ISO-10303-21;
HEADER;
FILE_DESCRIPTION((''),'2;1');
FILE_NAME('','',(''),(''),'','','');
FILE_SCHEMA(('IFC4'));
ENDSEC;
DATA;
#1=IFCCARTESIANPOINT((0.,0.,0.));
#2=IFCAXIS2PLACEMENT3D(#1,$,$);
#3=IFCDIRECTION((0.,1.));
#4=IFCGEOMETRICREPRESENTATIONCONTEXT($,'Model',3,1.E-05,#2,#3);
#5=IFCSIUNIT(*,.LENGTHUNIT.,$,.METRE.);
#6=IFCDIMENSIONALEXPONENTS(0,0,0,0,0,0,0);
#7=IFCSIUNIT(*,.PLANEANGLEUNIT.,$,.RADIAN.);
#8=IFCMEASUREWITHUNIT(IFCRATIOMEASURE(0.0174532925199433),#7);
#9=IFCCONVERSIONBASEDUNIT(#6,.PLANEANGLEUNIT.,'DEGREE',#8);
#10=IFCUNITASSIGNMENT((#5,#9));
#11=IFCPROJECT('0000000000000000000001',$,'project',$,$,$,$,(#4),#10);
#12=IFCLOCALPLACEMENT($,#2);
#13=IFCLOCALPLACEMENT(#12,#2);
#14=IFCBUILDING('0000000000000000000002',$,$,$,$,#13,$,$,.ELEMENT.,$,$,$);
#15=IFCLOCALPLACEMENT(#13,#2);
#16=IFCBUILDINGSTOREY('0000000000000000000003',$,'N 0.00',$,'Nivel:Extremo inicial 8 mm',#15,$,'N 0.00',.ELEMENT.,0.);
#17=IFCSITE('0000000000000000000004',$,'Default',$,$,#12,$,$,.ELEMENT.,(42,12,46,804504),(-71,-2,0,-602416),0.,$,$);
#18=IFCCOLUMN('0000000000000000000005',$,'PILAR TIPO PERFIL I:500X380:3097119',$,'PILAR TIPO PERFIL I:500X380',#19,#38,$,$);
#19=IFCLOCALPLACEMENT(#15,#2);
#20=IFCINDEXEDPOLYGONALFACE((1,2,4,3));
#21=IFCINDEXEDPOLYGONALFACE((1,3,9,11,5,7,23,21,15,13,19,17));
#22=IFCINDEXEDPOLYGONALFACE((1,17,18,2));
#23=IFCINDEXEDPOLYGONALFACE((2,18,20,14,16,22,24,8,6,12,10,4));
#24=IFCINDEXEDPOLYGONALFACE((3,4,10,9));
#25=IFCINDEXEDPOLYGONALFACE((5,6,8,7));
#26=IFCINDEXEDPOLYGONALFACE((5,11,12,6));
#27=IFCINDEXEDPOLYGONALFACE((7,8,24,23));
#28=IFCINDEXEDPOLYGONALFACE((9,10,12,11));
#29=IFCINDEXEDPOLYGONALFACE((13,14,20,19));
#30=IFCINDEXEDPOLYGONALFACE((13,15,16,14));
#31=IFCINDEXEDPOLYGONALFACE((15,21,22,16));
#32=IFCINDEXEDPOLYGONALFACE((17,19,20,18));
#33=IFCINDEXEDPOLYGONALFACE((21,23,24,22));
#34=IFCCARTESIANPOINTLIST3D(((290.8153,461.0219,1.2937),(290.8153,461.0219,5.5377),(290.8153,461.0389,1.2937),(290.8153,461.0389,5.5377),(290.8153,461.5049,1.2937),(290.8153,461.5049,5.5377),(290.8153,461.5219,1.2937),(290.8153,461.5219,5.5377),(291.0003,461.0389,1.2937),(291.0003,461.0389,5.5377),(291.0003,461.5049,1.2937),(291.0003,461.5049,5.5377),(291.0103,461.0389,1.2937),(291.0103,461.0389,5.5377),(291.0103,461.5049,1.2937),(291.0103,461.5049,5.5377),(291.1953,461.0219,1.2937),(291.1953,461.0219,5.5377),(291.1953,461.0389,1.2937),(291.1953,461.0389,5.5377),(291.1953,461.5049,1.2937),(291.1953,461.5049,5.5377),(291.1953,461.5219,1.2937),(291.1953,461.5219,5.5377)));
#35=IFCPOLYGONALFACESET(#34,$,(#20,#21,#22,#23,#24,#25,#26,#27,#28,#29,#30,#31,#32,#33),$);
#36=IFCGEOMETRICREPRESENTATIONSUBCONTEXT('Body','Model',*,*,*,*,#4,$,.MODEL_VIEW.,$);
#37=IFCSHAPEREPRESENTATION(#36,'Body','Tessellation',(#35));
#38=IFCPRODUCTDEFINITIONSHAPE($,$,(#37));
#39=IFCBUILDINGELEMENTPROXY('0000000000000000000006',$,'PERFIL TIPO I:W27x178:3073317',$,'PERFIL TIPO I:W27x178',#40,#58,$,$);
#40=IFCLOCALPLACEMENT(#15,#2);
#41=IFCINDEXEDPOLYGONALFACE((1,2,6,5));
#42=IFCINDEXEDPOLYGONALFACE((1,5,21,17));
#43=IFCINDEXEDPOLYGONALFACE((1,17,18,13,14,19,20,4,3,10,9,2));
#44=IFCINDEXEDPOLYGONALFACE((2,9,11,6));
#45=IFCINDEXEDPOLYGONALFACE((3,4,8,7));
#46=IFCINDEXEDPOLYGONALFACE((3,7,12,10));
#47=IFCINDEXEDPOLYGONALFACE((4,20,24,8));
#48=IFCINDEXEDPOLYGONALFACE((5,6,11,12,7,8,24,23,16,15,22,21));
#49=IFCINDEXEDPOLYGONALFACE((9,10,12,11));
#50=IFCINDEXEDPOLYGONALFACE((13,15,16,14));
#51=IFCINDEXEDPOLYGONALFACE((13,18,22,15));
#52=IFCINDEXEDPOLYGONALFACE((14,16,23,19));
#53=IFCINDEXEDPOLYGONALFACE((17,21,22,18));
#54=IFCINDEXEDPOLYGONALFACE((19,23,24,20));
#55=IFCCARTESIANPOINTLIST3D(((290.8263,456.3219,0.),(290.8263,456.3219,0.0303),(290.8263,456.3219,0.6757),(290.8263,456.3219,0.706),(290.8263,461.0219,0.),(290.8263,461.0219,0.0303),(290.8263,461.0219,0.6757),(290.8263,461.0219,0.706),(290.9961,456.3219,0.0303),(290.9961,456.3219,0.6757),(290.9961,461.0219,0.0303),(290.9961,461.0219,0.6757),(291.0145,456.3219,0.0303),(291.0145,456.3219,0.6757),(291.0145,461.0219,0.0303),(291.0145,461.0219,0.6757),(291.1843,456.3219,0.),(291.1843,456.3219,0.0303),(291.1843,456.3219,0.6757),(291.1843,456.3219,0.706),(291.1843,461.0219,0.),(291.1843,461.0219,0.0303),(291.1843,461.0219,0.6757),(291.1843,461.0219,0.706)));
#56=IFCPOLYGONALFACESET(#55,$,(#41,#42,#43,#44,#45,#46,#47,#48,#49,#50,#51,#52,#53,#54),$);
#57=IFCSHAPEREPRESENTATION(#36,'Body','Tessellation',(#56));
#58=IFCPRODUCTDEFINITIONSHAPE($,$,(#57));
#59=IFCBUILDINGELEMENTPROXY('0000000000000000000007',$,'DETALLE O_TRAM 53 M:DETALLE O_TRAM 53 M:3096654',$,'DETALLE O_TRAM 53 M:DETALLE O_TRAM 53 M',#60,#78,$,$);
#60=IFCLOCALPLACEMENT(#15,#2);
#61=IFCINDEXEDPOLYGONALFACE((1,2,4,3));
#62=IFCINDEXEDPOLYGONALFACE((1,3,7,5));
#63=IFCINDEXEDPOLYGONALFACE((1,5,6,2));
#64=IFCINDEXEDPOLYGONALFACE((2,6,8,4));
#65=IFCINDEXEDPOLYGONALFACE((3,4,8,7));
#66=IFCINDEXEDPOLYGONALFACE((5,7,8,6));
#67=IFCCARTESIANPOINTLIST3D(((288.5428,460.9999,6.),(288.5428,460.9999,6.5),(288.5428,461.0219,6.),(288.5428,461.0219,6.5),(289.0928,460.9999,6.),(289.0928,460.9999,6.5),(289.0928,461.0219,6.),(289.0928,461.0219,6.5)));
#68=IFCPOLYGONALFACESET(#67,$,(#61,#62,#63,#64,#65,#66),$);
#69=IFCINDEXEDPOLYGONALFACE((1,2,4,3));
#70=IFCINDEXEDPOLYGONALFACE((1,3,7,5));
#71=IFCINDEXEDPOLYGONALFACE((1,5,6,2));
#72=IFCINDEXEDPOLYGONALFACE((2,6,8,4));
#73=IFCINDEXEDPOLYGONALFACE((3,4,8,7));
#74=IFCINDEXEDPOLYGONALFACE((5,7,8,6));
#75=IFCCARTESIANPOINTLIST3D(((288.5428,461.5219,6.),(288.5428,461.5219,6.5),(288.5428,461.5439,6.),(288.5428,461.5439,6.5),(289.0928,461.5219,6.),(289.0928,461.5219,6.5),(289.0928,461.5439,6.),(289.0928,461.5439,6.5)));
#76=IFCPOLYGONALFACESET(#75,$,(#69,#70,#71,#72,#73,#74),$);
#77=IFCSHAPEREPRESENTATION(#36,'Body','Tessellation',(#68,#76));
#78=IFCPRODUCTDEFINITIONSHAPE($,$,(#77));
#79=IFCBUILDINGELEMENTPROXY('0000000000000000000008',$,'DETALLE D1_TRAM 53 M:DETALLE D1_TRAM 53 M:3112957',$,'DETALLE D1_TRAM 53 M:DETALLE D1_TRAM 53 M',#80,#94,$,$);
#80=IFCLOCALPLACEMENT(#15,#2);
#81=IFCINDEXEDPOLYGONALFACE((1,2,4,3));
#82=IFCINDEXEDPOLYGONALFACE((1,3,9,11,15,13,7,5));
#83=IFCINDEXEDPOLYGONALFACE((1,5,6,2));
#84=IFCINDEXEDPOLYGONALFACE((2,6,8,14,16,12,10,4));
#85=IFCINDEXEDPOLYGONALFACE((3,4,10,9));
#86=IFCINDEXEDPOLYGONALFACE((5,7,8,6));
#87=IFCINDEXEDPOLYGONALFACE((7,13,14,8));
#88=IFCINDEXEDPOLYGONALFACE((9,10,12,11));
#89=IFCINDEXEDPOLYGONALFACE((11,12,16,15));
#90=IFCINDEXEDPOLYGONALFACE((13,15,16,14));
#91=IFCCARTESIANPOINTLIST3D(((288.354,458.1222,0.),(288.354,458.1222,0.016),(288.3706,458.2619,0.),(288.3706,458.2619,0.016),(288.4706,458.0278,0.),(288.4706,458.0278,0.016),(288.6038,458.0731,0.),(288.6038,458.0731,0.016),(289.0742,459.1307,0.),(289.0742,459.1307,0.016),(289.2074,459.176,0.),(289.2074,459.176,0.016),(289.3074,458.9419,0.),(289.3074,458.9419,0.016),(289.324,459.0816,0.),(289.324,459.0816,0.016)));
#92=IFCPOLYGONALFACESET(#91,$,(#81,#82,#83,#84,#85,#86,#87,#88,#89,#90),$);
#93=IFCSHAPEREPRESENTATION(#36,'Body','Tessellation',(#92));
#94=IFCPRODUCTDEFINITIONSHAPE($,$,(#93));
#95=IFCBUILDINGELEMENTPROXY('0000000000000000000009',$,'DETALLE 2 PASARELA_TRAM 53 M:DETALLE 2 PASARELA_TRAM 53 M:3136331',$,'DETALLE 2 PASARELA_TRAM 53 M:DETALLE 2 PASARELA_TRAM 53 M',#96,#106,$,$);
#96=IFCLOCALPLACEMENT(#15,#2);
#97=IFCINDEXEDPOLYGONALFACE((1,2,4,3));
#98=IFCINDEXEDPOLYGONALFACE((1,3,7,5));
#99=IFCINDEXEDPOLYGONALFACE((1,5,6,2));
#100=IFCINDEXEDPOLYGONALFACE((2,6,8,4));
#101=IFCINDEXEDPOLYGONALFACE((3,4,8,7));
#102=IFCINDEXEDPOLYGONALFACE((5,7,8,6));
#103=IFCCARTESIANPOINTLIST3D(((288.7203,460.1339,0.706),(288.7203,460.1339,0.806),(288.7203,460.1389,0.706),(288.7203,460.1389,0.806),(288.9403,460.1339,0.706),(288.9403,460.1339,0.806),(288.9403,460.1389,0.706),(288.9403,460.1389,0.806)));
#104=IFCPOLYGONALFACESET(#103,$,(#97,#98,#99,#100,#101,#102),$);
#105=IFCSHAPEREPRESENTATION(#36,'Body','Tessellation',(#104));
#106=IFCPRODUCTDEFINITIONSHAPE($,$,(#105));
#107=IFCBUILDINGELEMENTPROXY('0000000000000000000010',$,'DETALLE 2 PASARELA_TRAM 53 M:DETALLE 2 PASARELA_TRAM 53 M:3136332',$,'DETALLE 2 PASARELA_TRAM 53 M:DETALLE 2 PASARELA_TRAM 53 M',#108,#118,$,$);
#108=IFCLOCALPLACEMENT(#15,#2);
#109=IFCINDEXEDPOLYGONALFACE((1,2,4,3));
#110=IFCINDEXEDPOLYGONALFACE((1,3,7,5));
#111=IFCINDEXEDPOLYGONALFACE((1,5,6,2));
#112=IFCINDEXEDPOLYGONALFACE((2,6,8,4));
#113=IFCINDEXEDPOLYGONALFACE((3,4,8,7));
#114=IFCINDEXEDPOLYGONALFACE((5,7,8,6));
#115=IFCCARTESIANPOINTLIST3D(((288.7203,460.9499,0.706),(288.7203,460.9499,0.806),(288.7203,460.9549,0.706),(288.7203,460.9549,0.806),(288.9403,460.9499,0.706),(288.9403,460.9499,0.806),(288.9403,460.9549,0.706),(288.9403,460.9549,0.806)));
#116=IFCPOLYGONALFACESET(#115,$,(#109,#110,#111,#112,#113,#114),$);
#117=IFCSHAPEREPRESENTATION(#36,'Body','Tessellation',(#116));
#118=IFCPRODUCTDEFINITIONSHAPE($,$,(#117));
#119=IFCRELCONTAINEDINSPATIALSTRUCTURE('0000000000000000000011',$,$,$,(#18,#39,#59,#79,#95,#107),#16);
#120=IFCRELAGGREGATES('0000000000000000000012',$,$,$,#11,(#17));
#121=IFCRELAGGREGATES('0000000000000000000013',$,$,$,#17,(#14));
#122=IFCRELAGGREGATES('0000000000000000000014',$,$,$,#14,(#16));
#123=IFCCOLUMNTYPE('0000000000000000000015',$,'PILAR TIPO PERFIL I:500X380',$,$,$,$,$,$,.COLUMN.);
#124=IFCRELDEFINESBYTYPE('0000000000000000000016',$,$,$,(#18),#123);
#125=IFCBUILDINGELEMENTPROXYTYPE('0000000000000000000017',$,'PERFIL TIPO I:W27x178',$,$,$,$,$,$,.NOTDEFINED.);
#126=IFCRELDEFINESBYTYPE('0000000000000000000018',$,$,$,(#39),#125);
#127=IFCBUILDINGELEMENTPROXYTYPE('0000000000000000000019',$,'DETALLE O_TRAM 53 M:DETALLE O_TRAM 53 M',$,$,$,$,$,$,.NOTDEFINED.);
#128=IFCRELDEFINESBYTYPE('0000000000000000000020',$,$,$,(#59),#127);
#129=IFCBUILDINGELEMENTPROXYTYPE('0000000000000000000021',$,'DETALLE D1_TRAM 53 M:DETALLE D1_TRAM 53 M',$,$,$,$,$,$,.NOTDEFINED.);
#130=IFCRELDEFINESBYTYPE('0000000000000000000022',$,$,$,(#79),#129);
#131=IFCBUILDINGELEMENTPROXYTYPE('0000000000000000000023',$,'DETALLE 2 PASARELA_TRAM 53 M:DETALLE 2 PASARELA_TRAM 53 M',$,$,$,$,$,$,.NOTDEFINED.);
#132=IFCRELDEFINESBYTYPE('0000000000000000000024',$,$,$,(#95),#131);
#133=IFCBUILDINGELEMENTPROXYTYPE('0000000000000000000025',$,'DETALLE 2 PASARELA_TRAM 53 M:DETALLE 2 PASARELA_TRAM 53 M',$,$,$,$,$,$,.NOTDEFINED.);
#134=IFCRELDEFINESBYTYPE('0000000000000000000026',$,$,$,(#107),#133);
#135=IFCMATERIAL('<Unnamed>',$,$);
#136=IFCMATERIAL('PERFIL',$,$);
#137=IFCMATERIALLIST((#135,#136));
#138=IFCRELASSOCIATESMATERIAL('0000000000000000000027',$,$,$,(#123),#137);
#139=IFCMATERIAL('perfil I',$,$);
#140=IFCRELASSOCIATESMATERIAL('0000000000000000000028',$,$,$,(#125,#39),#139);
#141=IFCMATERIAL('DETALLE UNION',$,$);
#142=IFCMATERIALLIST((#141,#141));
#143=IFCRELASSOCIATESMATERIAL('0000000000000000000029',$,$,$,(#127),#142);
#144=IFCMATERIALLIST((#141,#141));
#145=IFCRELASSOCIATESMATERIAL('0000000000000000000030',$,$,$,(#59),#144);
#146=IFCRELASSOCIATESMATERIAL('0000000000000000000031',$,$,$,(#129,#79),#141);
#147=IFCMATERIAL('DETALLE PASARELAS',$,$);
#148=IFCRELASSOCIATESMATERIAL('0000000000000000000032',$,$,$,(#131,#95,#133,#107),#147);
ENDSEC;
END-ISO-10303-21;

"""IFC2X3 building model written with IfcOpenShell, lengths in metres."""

from ifc_helpers import new_model, entity, si_unit, converted_unit, direction, frame, frame_2d, origin, place, context, subcontext, project, spatial, polyline, rectangle, i_section, outline, extrude, source, transform, mapped, material, material_list, type_object, type_shapes, element, save


model = new_model("IFC2X3")

# Units and contexts
model_context = context("Model", 3, precision=1e-05, world=origin(), true_north=direction((0.0, 1.0)))
body_context = subcontext(model_context, "Body", "Model", "MODEL_VIEW")
ifc_project = project(units=[si_unit("LENGTHUNIT", "METRE"), converted_unit("PLANEANGLEUNIT", "DEGREE", entity("IfcRatioMeasure", 0.0174532925199433), si_unit("PLANEANGLEUNIT", "RADIAN"), dimensions=[0, 0, 0, 0, 0, 0, 0])], contexts=[model_context])

# Site, building, storey
site_placement = place(None, origin())
site = spatial("IfcSite", under=ifc_project, at=site_placement, Name="Default", CompositionType="ELEMENT", RefLatitude=(42, 12, 46, 804504), RefLongitude=(-71, -2, 0, -602416), RefElevation=0.0)
building_placement = place(site_placement, origin())
building = spatial("IfcBuilding", under=site, at=building_placement, CompositionType="ELEMENT")
storey_placement = place(building_placement, origin())
storey = spatial("IfcBuildingStorey", under=building, at=storey_placement, Name="N 0.00", ObjectType="Nivel:Extremo inicial 8 mm", LongName="N 0.00", CompositionType="ELEMENT", Elevation=0.0)

# Column
ifc_material_1 = material(Name="<Unnamed>")
ifc_material_2 = material(Name="PERFIL")
ifc_material_list_1 = material_list([ifc_material_1, ifc_material_2])
column_type = type_object("IfcColumnType", Name="PILAR TIPO PERFIL I:500X380", PredefinedType="COLUMN", material=ifc_material_list_1)
shared_shape_1 = source(origin(), body_context, "Body", "SweptSolid", [
    extrude(i_section(OverallWidth=0.38, OverallDepth=0.5, WebThickness=0.01, FlangeThickness=0.017, at=frame_2d((0.0, 0.0), x_axis=(1.0, 0.0))), frame((0.0, 0.0, 1.2937), z_axis=(0.0, 0.0, 1.0), x_axis=(0.0, -1.0, 0.0)), (0.0, 0.0, 1.0), 4.244),
])
type_shapes(column_type, [shared_shape_1])
column_placement = place(storey_placement, frame((291.0053, 461.2719, 0.0), z_axis=(0.0, 0.0, 1.0), x_axis=(0.0, -1.0, 0.0)))
element("IfcColumn", 1, at=column_placement, inside=storey, type_object=column_type, Name="PILAR TIPO PERFIL I:500X380:3097119", ObjectType="PILAR TIPO PERFIL I:500X380", context=body_context, shape_type="MappedRepresentation", body=[
    mapped(shared_shape_1, transform((0.0, 0.0, 0.0), scale=1.0)),
])

# Building element proxies
ifc_material_3 = material(Name="perfil I")
building_element_proxy_type_1 = type_object("IfcBuildingElementProxyType", Name="PERFIL TIPO I:W27x178", PredefinedType="NOTDEFINED", material=ifc_material_3)
shared_shape_2 = source(origin(), body_context, "Body", "SweptSolid", [
    extrude(outline(polyline([(0.3227, -0.179), (0.353, -0.179), (0.353, 0.179), (0.3227, 0.179), (0.3227, 0.0092), (-0.3227, 0.0092), (-0.3227, 0.179), (-0.353, 0.179), (-0.353, -0.179), (-0.3227, -0.179), (-0.3227, -0.0092), (0.3227, -0.0092), (0.3227, -0.179)])), frame((0.0, 0.0, 0.353), z_axis=(1.0, 0.0, 0.0), x_axis=(0.0, 0.0, 1.0)), (0.0, 0.0, 1.0), 4.7),
])
type_shapes(building_element_proxy_type_1, [shared_shape_2])
proxy_1_placement = place(storey_placement, frame((291.0053, 461.0219, 0.0), z_axis=(0.0, 0.0, 1.0), x_axis=(0.0, -1.0, 0.0)))
element("IfcBuildingElementProxy", 2, at=proxy_1_placement, inside=storey, type_object=building_element_proxy_type_1, material=ifc_material_3, Name="PERFIL TIPO I:W27x178:3073317", ObjectType="PERFIL TIPO I:W27x178", context=body_context, shape_type="MappedRepresentation", body=[
    mapped(shared_shape_2, transform((0.0, 0.0, 0.0), scale=1.0)),
])
ifc_material_4 = material(Name="DETALLE UNION")
ifc_material_list_2 = material_list([ifc_material_4, ifc_material_4])
ifc_material_list_3 = material_list([ifc_material_4, ifc_material_4])
building_element_proxy_type_2 = type_object("IfcBuildingElementProxyType", Name="DETALLE O_TRAM 53 M:DETALLE O_TRAM 53 M", PredefinedType="NOTDEFINED", material=ifc_material_list_3)
shared_shape_3 = source(origin(), body_context, "Body", "SweptSolid", [
    extrude(rectangle(XDim=0.022, YDim=0.55, at=frame_2d((0.0, 0.0), x_axis=(1.0, 0.0))), frame((0.275, -0.011, 0.0), z_axis=(0.0, 0.0, 1.0), x_axis=(0.0, 1.0, 0.0)), (0.0, 0.0, 1.0), 0.5),
    extrude(rectangle(XDim=0.022, YDim=0.55, at=frame_2d((0.0, 0.0), x_axis=(1.0, 0.0))), frame((0.275, 0.511, 0.0), z_axis=(0.0, 0.0, 1.0), x_axis=(0.0, 1.0, 0.0)), (0.0, 0.0, 1.0), 0.5),
])
type_shapes(building_element_proxy_type_2, [shared_shape_3])
proxy_2_placement = place(storey_placement, frame((288.5428, 461.0219, 6.0)))
element("IfcBuildingElementProxy", 3, at=proxy_2_placement, inside=storey, type_object=building_element_proxy_type_2, material=ifc_material_list_2, Name="DETALLE O_TRAM 53 M:DETALLE O_TRAM 53 M:3096654", ObjectType="DETALLE O_TRAM 53 M:DETALLE O_TRAM 53 M", context=body_context, shape_type="MappedRepresentation", body=[
    mapped(shared_shape_3, transform((0.0, 0.0, 0.0), scale=1.0)),
])
building_element_proxy_type_3 = type_object("IfcBuildingElementProxyType", Name="DETALLE D1_TRAM 53 M:DETALLE D1_TRAM 53 M", PredefinedType="NOTDEFINED", material=ifc_material_4)
shared_shape_4 = source(origin(), body_context, "Body", "SweptSolid", [
    extrude(outline(polyline([(-0.075, -0.678), (0.075, -0.678), (0.15, -0.559), (0.15, 0.559), (0.075, 0.678), (-0.075, 0.678), (-0.15, 0.559), (-0.15, -0.559), (-0.075, -0.678)])), frame((0.0, 0.0, 0.0), z_axis=(0.0, 0.0, 1.0), x_axis=(-0.777146, 0.62932, 0.0)), (0.0, 0.0, 1.0), 0.016),
])
type_shapes(building_element_proxy_type_3, [shared_shape_4])
proxy_3_placement = place(storey_placement, frame((288.839, 458.6019, 0.0)))
element("IfcBuildingElementProxy", 4, at=proxy_3_placement, inside=storey, type_object=building_element_proxy_type_3, material=ifc_material_4, Name="DETALLE D1_TRAM 53 M:DETALLE D1_TRAM 53 M:3112957", ObjectType="DETALLE D1_TRAM 53 M:DETALLE D1_TRAM 53 M", context=body_context, shape_type="MappedRepresentation", body=[
    mapped(shared_shape_4, transform((0.0, 0.0, 0.0), scale=1.0)),
])
ifc_material_5 = material(Name="DETALLE PASARELAS")
building_element_proxy_type_4 = type_object("IfcBuildingElementProxyType", Name="DETALLE 2 PASARELA_TRAM 53 M:DETALLE 2 PASARELA_TRAM 53 M", PredefinedType="NOTDEFINED", material=ifc_material_5)
shared_shape_5 = source(origin(), body_context, "Body", "SweptSolid", [
    extrude(rectangle(XDim=0.22, YDim=0.005, at=frame_2d((0.0, 0.0), x_axis=(1.0, 0.0))), frame((0.11, 0.0475, 0.0), z_axis=(0.0, 0.0, 1.0), x_axis=(-1.0, 0.0, 0.0)), (0.0, 0.0, 1.0), 0.1),
])
type_shapes(building_element_proxy_type_4, [shared_shape_5])
proxy_4_placement = place(storey_placement, frame((288.7203, 460.0889, 0.706)))
element("IfcBuildingElementProxy", 5, at=proxy_4_placement, inside=storey, type_object=building_element_proxy_type_4, material=ifc_material_5, Name="DETALLE 2 PASARELA_TRAM 53 M:DETALLE 2 PASARELA_TRAM 53 M:3136331", ObjectType="DETALLE 2 PASARELA_TRAM 53 M:DETALLE 2 PASARELA_TRAM 53 M", context=body_context, shape_type="MappedRepresentation", body=[
    mapped(shared_shape_5, transform((0.0, 0.0, 0.0), scale=1.0)),
])
building_element_proxy_type_5 = type_object("IfcBuildingElementProxyType", Name="DETALLE 2 PASARELA_TRAM 53 M:DETALLE 2 PASARELA_TRAM 53 M", PredefinedType="NOTDEFINED", material=ifc_material_5)
shared_shape_6 = source(origin(), body_context, "Body", "SweptSolid", [
    extrude(rectangle(XDim=0.005, YDim=0.22, at=frame_2d((0.0, 0.0), x_axis=(1.0, 0.0))), frame((0.11, -0.0475, 0.0), z_axis=(0.0, 0.0, 1.0), x_axis=(0.0, 1.0, 0.0)), (0.0, 0.0, 1.0), 0.1),
])
type_shapes(building_element_proxy_type_5, [shared_shape_6])
proxy_5_placement = place(storey_placement, frame((288.7203, 460.9999, 0.706)))
element("IfcBuildingElementProxy", 6, at=proxy_5_placement, inside=storey, type_object=building_element_proxy_type_5, material=ifc_material_5, Name="DETALLE 2 PASARELA_TRAM 53 M:DETALLE 2 PASARELA_TRAM 53 M:3136332", ObjectType="DETALLE 2 PASARELA_TRAM 53 M:DETALLE 2 PASARELA_TRAM 53 M", context=body_context, shape_type="MappedRepresentation", body=[
    mapped(shared_shape_6, transform((0.0, 0.0, 0.0), scale=1.0)),
])

save(model, "model.ifc")
